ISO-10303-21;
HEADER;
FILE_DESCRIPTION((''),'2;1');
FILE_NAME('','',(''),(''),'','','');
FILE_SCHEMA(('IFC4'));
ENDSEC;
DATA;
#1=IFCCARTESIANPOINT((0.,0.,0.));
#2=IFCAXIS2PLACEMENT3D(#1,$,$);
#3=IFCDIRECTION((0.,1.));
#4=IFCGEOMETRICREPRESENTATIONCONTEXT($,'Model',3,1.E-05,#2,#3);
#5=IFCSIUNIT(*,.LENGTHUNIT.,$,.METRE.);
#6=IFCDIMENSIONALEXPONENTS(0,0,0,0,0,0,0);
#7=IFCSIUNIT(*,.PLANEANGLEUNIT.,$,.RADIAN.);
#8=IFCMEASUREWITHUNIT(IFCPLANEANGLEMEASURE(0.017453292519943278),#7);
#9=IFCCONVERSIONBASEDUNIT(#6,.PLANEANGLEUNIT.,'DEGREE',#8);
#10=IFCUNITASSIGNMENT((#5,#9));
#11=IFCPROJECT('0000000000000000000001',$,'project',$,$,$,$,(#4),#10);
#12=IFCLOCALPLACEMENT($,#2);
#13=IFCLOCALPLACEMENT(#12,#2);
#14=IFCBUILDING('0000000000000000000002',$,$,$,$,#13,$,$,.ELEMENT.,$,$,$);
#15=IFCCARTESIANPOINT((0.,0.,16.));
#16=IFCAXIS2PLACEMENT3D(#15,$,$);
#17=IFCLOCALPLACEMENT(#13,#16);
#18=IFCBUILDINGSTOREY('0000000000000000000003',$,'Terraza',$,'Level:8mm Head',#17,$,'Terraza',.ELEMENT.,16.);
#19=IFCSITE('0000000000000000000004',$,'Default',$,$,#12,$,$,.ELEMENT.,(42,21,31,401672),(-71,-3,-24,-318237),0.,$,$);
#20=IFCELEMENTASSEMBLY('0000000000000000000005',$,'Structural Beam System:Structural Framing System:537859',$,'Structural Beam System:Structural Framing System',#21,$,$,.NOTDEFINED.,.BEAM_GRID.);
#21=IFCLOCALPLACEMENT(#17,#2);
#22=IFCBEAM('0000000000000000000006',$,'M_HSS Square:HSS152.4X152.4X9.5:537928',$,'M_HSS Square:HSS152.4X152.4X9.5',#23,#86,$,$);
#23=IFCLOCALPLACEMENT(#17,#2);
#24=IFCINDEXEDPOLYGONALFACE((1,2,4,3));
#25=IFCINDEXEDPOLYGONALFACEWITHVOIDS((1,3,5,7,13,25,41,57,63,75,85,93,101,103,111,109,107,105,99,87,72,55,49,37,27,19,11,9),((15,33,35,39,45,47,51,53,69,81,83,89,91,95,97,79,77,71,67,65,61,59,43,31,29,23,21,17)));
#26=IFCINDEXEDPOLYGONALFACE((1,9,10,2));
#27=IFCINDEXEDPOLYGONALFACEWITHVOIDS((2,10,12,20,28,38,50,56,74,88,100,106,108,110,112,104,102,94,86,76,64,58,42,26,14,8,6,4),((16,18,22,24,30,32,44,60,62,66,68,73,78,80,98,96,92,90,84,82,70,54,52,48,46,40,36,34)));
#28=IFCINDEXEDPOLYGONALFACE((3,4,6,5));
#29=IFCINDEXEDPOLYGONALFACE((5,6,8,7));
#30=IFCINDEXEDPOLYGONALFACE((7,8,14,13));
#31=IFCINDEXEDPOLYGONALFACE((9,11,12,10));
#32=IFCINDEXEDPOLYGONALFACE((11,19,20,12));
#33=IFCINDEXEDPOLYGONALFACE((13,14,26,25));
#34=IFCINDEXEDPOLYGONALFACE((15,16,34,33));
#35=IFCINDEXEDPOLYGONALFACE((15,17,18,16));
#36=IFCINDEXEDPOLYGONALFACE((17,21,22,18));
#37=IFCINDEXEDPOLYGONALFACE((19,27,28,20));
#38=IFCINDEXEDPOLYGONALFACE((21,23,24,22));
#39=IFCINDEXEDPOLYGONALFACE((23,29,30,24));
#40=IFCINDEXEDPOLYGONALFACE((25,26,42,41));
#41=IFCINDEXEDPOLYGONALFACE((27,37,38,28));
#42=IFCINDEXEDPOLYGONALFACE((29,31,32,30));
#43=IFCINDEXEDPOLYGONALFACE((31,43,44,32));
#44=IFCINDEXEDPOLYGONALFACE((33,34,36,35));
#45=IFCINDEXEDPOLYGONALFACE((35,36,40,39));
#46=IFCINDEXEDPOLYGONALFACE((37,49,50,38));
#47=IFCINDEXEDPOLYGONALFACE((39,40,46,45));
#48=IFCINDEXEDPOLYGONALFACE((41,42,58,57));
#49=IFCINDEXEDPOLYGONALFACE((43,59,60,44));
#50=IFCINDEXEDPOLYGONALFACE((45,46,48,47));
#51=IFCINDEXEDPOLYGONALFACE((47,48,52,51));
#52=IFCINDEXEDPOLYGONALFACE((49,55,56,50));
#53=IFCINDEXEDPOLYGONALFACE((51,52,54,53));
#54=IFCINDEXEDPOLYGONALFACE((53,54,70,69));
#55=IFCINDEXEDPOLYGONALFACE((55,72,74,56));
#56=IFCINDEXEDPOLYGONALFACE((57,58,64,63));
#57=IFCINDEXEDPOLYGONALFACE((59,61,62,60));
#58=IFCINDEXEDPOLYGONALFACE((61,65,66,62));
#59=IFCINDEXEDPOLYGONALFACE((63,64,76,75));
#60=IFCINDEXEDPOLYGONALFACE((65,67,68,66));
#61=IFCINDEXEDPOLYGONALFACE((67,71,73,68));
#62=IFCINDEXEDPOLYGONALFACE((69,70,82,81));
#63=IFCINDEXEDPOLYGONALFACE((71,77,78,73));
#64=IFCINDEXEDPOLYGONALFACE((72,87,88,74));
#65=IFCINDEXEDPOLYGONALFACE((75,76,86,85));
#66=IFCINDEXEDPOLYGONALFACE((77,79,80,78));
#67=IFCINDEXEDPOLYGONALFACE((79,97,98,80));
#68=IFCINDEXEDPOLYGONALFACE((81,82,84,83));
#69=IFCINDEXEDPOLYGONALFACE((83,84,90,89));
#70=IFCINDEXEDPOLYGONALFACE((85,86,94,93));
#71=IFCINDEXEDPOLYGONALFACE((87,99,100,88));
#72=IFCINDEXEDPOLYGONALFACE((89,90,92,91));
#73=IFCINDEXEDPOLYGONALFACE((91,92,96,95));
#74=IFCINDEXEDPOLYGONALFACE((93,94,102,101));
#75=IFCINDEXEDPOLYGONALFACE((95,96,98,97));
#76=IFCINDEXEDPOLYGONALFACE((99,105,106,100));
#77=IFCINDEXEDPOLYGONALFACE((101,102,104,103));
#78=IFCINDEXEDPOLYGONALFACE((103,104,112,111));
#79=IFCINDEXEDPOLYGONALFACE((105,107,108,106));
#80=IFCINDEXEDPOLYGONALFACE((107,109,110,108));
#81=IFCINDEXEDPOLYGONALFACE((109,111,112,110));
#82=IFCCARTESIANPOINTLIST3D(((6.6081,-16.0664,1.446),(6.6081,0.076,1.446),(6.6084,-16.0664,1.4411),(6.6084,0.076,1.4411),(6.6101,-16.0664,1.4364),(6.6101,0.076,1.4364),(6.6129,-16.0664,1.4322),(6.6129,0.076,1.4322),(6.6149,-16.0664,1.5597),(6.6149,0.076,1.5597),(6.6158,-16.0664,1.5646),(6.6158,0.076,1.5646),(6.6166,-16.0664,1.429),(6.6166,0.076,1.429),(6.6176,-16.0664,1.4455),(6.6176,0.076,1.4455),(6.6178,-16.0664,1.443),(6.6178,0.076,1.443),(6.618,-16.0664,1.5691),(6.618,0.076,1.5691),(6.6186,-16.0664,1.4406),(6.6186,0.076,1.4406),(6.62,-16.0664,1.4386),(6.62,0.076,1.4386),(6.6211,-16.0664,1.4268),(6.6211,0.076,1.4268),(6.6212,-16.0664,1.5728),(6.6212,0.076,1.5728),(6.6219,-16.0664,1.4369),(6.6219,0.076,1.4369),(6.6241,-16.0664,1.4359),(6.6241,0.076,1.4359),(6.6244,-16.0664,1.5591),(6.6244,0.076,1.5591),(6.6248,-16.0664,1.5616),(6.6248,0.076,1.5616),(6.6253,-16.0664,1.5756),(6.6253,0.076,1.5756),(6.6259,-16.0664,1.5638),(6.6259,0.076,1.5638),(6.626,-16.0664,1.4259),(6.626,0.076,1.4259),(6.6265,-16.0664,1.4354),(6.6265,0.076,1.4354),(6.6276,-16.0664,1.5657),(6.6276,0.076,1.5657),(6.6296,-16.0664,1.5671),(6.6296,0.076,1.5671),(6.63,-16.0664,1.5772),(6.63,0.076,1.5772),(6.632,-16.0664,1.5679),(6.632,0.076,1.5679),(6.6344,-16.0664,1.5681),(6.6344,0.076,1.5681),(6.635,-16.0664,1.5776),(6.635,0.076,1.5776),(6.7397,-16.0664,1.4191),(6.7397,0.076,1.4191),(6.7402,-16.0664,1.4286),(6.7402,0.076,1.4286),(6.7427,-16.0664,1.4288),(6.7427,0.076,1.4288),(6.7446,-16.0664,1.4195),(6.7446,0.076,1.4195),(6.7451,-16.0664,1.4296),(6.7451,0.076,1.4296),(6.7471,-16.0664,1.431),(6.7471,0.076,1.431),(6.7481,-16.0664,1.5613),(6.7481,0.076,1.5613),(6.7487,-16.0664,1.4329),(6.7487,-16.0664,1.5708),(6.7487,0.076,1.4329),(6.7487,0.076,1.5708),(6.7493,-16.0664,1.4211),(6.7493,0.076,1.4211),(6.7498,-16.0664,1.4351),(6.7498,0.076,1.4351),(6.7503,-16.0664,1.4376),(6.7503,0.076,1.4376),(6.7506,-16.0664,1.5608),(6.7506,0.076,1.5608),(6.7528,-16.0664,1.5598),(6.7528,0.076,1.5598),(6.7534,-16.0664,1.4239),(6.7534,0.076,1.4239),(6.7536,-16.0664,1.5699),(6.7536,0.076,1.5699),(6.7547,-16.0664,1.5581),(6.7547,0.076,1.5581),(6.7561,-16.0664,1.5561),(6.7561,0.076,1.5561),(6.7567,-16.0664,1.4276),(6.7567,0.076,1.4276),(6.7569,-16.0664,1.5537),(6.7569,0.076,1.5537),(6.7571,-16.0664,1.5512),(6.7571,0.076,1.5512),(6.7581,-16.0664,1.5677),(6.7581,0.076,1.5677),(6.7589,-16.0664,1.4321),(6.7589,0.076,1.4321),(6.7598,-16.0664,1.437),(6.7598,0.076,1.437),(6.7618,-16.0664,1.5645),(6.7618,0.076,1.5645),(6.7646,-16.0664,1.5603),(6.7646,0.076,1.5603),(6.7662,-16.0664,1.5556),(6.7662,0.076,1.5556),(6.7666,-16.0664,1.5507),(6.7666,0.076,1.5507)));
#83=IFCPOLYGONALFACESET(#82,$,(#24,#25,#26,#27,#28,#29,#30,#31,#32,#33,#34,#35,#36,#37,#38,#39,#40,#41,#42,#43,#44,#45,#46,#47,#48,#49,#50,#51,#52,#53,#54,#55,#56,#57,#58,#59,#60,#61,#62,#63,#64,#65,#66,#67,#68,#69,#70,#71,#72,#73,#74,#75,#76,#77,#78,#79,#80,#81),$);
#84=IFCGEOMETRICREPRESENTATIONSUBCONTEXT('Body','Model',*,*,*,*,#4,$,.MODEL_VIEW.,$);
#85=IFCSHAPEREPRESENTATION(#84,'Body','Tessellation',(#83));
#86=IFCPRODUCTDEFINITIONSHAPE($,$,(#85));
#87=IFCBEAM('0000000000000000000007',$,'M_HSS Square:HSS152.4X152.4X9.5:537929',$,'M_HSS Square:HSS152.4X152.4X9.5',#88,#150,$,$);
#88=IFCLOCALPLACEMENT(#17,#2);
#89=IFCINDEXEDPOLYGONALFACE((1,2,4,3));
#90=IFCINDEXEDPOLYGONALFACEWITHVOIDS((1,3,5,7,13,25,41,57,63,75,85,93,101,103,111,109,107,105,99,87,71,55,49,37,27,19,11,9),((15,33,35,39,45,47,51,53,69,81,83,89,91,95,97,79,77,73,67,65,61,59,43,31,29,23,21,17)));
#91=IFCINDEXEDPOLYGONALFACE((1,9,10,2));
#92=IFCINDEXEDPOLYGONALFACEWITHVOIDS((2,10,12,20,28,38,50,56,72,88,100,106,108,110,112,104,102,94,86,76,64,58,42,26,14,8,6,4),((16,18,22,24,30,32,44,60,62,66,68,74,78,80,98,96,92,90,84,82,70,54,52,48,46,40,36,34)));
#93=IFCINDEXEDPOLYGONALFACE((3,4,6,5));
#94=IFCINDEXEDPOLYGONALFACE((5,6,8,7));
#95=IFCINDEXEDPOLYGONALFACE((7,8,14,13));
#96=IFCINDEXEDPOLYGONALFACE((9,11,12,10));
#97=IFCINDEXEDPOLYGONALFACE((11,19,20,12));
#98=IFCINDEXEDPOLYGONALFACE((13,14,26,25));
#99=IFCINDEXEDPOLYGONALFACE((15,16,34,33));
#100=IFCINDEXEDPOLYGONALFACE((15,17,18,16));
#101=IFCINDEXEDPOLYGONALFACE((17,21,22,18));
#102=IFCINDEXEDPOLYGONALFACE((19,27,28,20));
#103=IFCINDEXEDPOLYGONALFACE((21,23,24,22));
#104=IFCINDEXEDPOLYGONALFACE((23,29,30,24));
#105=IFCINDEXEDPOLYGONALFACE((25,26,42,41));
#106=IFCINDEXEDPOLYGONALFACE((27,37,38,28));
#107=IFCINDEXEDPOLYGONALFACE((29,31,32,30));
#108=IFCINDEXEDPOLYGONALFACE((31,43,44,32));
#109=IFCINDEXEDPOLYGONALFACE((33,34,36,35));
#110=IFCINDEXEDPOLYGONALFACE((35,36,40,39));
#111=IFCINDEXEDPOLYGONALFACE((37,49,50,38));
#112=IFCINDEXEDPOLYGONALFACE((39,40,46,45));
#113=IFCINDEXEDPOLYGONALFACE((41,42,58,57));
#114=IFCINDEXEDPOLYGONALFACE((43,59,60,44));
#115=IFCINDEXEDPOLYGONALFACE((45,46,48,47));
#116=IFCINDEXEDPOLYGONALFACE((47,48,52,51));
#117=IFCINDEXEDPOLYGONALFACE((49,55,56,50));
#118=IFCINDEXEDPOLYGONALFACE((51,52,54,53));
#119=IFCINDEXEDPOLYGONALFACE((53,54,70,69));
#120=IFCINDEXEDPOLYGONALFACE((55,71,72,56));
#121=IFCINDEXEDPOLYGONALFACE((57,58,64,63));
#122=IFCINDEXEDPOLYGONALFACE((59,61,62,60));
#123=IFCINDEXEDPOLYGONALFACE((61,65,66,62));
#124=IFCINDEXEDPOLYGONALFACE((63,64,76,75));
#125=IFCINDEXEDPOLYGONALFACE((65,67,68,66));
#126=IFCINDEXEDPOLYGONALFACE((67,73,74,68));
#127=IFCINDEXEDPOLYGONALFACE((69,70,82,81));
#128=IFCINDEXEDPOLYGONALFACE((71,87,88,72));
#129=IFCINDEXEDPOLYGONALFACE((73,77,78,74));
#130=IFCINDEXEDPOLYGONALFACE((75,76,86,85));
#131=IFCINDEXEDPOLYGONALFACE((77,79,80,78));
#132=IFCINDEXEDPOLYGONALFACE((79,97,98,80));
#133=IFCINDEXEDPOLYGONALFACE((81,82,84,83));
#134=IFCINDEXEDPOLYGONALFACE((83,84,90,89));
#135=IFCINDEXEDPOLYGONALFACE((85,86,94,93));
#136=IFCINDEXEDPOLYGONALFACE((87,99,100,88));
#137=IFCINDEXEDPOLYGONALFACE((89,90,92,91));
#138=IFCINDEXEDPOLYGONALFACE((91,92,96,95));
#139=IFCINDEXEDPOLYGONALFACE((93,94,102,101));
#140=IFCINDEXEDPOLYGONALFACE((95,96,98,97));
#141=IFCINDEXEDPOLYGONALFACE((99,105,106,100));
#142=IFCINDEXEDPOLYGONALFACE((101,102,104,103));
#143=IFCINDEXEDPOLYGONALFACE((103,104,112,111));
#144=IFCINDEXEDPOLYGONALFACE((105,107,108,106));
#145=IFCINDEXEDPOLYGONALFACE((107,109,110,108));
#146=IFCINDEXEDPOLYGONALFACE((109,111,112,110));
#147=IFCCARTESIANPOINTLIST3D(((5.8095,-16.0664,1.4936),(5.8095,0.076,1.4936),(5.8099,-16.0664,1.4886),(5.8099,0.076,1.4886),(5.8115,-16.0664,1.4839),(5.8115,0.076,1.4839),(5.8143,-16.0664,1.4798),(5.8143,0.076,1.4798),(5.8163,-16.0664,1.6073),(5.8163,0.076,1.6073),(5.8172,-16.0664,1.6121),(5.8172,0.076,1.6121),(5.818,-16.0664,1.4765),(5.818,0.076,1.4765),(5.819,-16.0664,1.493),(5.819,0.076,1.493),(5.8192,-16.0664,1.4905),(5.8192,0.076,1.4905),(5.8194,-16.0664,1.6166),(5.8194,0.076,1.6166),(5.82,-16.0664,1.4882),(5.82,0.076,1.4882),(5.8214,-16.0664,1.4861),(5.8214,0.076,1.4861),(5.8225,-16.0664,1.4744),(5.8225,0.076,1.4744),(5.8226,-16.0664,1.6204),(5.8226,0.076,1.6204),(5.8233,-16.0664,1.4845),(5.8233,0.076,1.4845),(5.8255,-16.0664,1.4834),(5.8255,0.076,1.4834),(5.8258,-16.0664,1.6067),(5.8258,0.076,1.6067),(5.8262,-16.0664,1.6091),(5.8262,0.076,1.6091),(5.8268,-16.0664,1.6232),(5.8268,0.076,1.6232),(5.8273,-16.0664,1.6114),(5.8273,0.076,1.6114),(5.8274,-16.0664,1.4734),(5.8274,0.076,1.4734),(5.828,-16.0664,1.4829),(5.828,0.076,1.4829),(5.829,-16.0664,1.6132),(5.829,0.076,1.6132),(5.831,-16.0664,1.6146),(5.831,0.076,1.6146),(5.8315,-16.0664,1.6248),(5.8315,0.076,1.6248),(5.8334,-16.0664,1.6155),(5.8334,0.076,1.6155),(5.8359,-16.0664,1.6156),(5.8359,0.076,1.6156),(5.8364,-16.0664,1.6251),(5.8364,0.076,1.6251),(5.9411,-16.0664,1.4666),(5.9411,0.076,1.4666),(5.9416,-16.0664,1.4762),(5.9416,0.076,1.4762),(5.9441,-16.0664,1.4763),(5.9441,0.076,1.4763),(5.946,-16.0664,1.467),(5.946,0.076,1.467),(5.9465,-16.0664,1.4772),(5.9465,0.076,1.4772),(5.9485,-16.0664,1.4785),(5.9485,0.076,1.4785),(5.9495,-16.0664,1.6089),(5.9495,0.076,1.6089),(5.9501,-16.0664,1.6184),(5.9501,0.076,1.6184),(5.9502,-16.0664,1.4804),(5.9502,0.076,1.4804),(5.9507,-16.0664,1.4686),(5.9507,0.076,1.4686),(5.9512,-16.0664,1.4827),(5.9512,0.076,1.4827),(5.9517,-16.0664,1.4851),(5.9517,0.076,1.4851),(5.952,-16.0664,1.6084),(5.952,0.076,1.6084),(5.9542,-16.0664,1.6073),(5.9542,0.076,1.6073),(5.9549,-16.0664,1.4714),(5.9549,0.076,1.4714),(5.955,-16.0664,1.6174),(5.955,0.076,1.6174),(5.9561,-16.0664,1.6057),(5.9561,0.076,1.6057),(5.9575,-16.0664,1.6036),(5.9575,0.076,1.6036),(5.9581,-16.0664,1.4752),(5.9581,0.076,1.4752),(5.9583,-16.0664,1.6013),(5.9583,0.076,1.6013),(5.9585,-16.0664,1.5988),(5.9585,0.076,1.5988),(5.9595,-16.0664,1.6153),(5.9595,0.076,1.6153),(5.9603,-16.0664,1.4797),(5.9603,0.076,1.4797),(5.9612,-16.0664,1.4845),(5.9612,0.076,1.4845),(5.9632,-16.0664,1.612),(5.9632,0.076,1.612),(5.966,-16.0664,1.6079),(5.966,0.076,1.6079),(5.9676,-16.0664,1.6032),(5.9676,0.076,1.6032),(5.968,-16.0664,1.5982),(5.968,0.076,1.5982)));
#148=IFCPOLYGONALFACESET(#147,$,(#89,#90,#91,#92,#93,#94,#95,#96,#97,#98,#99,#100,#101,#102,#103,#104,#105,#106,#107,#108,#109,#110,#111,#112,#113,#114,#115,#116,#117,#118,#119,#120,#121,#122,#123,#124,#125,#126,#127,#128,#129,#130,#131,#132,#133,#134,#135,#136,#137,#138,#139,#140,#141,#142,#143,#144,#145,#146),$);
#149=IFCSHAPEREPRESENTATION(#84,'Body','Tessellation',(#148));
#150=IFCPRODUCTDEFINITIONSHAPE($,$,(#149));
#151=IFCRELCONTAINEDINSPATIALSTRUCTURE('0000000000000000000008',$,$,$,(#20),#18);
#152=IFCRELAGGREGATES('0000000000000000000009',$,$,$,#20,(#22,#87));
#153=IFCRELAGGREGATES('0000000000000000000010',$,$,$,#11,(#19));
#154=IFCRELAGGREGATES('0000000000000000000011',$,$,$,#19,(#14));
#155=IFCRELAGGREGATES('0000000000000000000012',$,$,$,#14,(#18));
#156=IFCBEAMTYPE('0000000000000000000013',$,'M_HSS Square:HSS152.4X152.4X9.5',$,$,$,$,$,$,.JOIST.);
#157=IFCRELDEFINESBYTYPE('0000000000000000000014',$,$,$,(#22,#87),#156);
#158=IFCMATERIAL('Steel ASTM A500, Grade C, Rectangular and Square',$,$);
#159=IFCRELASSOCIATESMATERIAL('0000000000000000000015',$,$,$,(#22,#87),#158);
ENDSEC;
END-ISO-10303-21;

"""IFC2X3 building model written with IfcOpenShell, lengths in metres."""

from ifc_helpers import new_model, entity, si_unit, converted_unit, direction, frame, frame_2d, origin, place, context, subcontext, project, spatial, polyline, circle_curve, parameter, trimmed, segment, composite_curve, outline, extrude, material, type_object, element, aggregate, save


model = new_model("IFC2X3")

# Units and contexts
model_context = context("Model", 3, precision=1e-05, world=origin(), true_north=direction((0.0, 1.0)))
body_context = subcontext(model_context, "Body", "Model", "MODEL_VIEW")
ifc_project = project(units=[si_unit("LENGTHUNIT", "METRE"), converted_unit("PLANEANGLEUNIT", "DEGREE", entity("IfcPlaneAngleMeasure", 0.017453292519943278), si_unit("PLANEANGLEUNIT", "RADIAN"), dimensions=[0, 0, 0, 0, 0, 0, 0])], contexts=[model_context])

# Site, building, storey
site_placement = place(None, origin())
site = spatial("IfcSite", under=ifc_project, at=site_placement, Name="Default", CompositionType="ELEMENT", RefLatitude=(42, 21, 31, 401672), RefLongitude=(-71, -3, -24, -318237), RefElevation=0.0)
building_placement = place(site_placement, origin())
building = spatial("IfcBuilding", under=site, at=building_placement, CompositionType="ELEMENT")
storey_placement = place(building_placement, frame((0.0, 0.0, 16.0)))
storey = spatial("IfcBuildingStorey", under=building, at=storey_placement, Name="Terraza", ObjectType="Level:8mm Head", LongName="Terraza", CompositionType="ELEMENT", Elevation=16.0)

# Element assembly, beams
assembly_1_placement = place(storey_placement, origin())
assembly_1 = element("IfcElementAssembly", 1, at=assembly_1_placement, inside=storey, Name="Structural Beam System:Structural Framing System:537859", ObjectType="Structural Beam System:Structural Framing System", AssemblyPlace="NOTDEFINED", PredefinedType="BEAM_GRID")
ifc_material_1 = material(Name="Steel ASTM A500, Grade C, Rectangular and Square")
beam_type = type_object("IfcBeamType", Name="M_HSS Square:HSS152.4X152.4X9.5", PredefinedType="JOIST")
beam_1_placement = place(assembly_1_placement, frame((6.6828, 0.076, 1.4225), z_axis=(0.0, 0.0, 1.0), x_axis=(0.0, -1.0, 0.0)))
beam_1 = element("IfcBeam", 2, at=beam_1_placement, type_object=beam_type, material=ifc_material_1, Name="M_HSS Square:HSS152.4X152.4X9.5:537928", ObjectType="M_HSS Square:HSS152.4X152.4X9.5", context=body_context, shape_type="SweptSolid", body=[
    extrude(outline(composite_curve([segment(polyline([(-0.0569, -0.076), (0.0569, -0.076)]), True, "CONTINUOUS"), segment(trimmed(circle_curve(frame_2d((0.0569, -0.0569), x_axis=(0.0, 1.0)), 0.0191), [parameter(180.0)], [parameter(270.0)], True, "PARAMETER"), True, "CONTINUOUS"), segment(polyline([(0.076, -0.0569), (0.076, 0.0569)]), True, "CONTINUOUS"), segment(trimmed(circle_curve(frame_2d((0.0569, 0.0569), x_axis=(0.0, 1.0)), 0.0191), [parameter(270.0)], [parameter(0.0)], True, "PARAMETER"), True, "CONTINUOUS"), segment(polyline([(0.0569, 0.076), (-0.0569, 0.076)]), True, "CONTINUOUS"), segment(trimmed(circle_curve(frame_2d((-0.0569, 0.0569), x_axis=(0.0, 1.0)), 0.0191), [parameter(0.0)], [parameter(90.0)], True, "PARAMETER"), True, "CONTINUOUS"), segment(polyline([(-0.076, 0.0569), (-0.076, -0.0569)]), True, "CONTINUOUS"), segment(trimmed(circle_curve(frame_2d((-0.0569, -0.0569), x_axis=(0.0, 1.0)), 0.0191), [parameter(90.0)], [parameter(180.0)], True, "PARAMETER"), True, "CONTINUOUS")], self_intersect=False), holes=[composite_curve([segment(trimmed(circle_curve(frame_2d((-0.0569, 0.0569), x_axis=(0.0, 1.0)), 0.0095), [parameter(360.0)], [parameter(90.0)], True, "PARAMETER"), False, "CONTINUOUS"), segment(polyline([(-0.0569, 0.0665), (0.0569, 0.0665)]), True, "CONTINUOUS"), segment(trimmed(circle_curve(frame_2d((0.0569, 0.0569), x_axis=(0.0, 1.0)), 0.0095), [parameter(270.0)], [parameter(360.0)], True, "PARAMETER"), False, "CONTINUOUS"), segment(polyline([(0.0665, 0.0569), (0.0665, -0.0569)]), True, "CONTINUOUS"), segment(trimmed(circle_curve(frame_2d((0.0569, -0.0569), x_axis=(0.0, 1.0)), 0.0095), [parameter(180.0)], [parameter(270.0)], True, "PARAMETER"), False, "CONTINUOUS"), segment(polyline([(0.0569, -0.0665), (-0.0569, -0.0665)]), True, "CONTINUOUS"), segment(trimmed(circle_curve(frame_2d((-0.0569, -0.0569), x_axis=(0.0, 1.0)), 0.0095), [parameter(90.0)], [parameter(180.0)], True, "PARAMETER"), False, "CONTINUOUS"), segment(polyline([(-0.0665, -0.0569), (-0.0665, 0.0569)]), True, "CONTINUOUS")], self_intersect=False)]), frame((0.0, 0.0045, 0.0759), z_axis=(1.0, 0.0, 0.0), x_axis=(0.0, -0.059434, -0.998232)), (0.0, 0.0, 1.0), 16.1424),
])
beam_2_placement = place(assembly_1_placement, frame((5.8842, 0.076, 1.47), z_axis=(0.0, 0.0, 1.0), x_axis=(0.0, -1.0, 0.0)))
beam_2 = element("IfcBeam", 3, at=beam_2_placement, type_object=beam_type, material=ifc_material_1, Name="M_HSS Square:HSS152.4X152.4X9.5:537929", ObjectType="M_HSS Square:HSS152.4X152.4X9.5", context=body_context, shape_type="SweptSolid", body=[
    extrude(outline(composite_curve([segment(polyline([(-0.0569, -0.076), (0.0569, -0.076)]), True, "CONTINUOUS"), segment(trimmed(circle_curve(frame_2d((0.0569, -0.0569), x_axis=(0.0, 1.0)), 0.0191), [parameter(180.0)], [parameter(270.0)], True, "PARAMETER"), True, "CONTINUOUS"), segment(polyline([(0.076, -0.0569), (0.076, 0.0569)]), True, "CONTINUOUS"), segment(trimmed(circle_curve(frame_2d((0.0569, 0.0569), x_axis=(0.0, 1.0)), 0.0191), [parameter(270.0)], [parameter(0.0)], True, "PARAMETER"), True, "CONTINUOUS"), segment(polyline([(0.0569, 0.076), (-0.0569, 0.076)]), True, "CONTINUOUS"), segment(trimmed(circle_curve(frame_2d((-0.0569, 0.0569), x_axis=(0.0, 1.0)), 0.0191), [parameter(0.0)], [parameter(90.0)], True, "PARAMETER"), True, "CONTINUOUS"), segment(polyline([(-0.076, 0.0569), (-0.076, -0.0569)]), True, "CONTINUOUS"), segment(trimmed(circle_curve(frame_2d((-0.0569, -0.0569), x_axis=(0.0, 1.0)), 0.0191), [parameter(90.0)], [parameter(180.0)], True, "PARAMETER"), True, "CONTINUOUS")], self_intersect=False), holes=[composite_curve([segment(trimmed(circle_curve(frame_2d((-0.0569, 0.0569), x_axis=(0.0, 1.0)), 0.0095), [parameter(360.0)], [parameter(90.0)], True, "PARAMETER"), False, "CONTINUOUS"), segment(polyline([(-0.0569, 0.0665), (0.0569, 0.0665)]), True, "CONTINUOUS"), segment(trimmed(circle_curve(frame_2d((0.0569, 0.0569), x_axis=(0.0, 1.0)), 0.0095), [parameter(270.0)], [parameter(360.0)], True, "PARAMETER"), False, "CONTINUOUS"), segment(polyline([(0.0665, 0.0569), (0.0665, -0.0569)]), True, "CONTINUOUS"), segment(trimmed(circle_curve(frame_2d((0.0569, -0.0569), x_axis=(0.0, 1.0)), 0.0095), [parameter(180.0)], [parameter(270.0)], True, "PARAMETER"), False, "CONTINUOUS"), segment(polyline([(0.0569, -0.0665), (-0.0569, -0.0665)]), True, "CONTINUOUS"), segment(trimmed(circle_curve(frame_2d((-0.0569, -0.0569), x_axis=(0.0, 1.0)), 0.0095), [parameter(90.0)], [parameter(180.0)], True, "PARAMETER"), False, "CONTINUOUS"), segment(polyline([(-0.0665, -0.0569), (-0.0665, 0.0569)]), True, "CONTINUOUS")], self_intersect=False)]), frame((0.0, 0.0045, 0.0759), z_axis=(1.0, 0.0, 0.0), x_axis=(0.0, -0.059434, -0.998232)), (0.0, 0.0, 1.0), 16.1424),
])
aggregate(assembly_1, [beam_1, beam_2])

save(model, "model.ifc")
